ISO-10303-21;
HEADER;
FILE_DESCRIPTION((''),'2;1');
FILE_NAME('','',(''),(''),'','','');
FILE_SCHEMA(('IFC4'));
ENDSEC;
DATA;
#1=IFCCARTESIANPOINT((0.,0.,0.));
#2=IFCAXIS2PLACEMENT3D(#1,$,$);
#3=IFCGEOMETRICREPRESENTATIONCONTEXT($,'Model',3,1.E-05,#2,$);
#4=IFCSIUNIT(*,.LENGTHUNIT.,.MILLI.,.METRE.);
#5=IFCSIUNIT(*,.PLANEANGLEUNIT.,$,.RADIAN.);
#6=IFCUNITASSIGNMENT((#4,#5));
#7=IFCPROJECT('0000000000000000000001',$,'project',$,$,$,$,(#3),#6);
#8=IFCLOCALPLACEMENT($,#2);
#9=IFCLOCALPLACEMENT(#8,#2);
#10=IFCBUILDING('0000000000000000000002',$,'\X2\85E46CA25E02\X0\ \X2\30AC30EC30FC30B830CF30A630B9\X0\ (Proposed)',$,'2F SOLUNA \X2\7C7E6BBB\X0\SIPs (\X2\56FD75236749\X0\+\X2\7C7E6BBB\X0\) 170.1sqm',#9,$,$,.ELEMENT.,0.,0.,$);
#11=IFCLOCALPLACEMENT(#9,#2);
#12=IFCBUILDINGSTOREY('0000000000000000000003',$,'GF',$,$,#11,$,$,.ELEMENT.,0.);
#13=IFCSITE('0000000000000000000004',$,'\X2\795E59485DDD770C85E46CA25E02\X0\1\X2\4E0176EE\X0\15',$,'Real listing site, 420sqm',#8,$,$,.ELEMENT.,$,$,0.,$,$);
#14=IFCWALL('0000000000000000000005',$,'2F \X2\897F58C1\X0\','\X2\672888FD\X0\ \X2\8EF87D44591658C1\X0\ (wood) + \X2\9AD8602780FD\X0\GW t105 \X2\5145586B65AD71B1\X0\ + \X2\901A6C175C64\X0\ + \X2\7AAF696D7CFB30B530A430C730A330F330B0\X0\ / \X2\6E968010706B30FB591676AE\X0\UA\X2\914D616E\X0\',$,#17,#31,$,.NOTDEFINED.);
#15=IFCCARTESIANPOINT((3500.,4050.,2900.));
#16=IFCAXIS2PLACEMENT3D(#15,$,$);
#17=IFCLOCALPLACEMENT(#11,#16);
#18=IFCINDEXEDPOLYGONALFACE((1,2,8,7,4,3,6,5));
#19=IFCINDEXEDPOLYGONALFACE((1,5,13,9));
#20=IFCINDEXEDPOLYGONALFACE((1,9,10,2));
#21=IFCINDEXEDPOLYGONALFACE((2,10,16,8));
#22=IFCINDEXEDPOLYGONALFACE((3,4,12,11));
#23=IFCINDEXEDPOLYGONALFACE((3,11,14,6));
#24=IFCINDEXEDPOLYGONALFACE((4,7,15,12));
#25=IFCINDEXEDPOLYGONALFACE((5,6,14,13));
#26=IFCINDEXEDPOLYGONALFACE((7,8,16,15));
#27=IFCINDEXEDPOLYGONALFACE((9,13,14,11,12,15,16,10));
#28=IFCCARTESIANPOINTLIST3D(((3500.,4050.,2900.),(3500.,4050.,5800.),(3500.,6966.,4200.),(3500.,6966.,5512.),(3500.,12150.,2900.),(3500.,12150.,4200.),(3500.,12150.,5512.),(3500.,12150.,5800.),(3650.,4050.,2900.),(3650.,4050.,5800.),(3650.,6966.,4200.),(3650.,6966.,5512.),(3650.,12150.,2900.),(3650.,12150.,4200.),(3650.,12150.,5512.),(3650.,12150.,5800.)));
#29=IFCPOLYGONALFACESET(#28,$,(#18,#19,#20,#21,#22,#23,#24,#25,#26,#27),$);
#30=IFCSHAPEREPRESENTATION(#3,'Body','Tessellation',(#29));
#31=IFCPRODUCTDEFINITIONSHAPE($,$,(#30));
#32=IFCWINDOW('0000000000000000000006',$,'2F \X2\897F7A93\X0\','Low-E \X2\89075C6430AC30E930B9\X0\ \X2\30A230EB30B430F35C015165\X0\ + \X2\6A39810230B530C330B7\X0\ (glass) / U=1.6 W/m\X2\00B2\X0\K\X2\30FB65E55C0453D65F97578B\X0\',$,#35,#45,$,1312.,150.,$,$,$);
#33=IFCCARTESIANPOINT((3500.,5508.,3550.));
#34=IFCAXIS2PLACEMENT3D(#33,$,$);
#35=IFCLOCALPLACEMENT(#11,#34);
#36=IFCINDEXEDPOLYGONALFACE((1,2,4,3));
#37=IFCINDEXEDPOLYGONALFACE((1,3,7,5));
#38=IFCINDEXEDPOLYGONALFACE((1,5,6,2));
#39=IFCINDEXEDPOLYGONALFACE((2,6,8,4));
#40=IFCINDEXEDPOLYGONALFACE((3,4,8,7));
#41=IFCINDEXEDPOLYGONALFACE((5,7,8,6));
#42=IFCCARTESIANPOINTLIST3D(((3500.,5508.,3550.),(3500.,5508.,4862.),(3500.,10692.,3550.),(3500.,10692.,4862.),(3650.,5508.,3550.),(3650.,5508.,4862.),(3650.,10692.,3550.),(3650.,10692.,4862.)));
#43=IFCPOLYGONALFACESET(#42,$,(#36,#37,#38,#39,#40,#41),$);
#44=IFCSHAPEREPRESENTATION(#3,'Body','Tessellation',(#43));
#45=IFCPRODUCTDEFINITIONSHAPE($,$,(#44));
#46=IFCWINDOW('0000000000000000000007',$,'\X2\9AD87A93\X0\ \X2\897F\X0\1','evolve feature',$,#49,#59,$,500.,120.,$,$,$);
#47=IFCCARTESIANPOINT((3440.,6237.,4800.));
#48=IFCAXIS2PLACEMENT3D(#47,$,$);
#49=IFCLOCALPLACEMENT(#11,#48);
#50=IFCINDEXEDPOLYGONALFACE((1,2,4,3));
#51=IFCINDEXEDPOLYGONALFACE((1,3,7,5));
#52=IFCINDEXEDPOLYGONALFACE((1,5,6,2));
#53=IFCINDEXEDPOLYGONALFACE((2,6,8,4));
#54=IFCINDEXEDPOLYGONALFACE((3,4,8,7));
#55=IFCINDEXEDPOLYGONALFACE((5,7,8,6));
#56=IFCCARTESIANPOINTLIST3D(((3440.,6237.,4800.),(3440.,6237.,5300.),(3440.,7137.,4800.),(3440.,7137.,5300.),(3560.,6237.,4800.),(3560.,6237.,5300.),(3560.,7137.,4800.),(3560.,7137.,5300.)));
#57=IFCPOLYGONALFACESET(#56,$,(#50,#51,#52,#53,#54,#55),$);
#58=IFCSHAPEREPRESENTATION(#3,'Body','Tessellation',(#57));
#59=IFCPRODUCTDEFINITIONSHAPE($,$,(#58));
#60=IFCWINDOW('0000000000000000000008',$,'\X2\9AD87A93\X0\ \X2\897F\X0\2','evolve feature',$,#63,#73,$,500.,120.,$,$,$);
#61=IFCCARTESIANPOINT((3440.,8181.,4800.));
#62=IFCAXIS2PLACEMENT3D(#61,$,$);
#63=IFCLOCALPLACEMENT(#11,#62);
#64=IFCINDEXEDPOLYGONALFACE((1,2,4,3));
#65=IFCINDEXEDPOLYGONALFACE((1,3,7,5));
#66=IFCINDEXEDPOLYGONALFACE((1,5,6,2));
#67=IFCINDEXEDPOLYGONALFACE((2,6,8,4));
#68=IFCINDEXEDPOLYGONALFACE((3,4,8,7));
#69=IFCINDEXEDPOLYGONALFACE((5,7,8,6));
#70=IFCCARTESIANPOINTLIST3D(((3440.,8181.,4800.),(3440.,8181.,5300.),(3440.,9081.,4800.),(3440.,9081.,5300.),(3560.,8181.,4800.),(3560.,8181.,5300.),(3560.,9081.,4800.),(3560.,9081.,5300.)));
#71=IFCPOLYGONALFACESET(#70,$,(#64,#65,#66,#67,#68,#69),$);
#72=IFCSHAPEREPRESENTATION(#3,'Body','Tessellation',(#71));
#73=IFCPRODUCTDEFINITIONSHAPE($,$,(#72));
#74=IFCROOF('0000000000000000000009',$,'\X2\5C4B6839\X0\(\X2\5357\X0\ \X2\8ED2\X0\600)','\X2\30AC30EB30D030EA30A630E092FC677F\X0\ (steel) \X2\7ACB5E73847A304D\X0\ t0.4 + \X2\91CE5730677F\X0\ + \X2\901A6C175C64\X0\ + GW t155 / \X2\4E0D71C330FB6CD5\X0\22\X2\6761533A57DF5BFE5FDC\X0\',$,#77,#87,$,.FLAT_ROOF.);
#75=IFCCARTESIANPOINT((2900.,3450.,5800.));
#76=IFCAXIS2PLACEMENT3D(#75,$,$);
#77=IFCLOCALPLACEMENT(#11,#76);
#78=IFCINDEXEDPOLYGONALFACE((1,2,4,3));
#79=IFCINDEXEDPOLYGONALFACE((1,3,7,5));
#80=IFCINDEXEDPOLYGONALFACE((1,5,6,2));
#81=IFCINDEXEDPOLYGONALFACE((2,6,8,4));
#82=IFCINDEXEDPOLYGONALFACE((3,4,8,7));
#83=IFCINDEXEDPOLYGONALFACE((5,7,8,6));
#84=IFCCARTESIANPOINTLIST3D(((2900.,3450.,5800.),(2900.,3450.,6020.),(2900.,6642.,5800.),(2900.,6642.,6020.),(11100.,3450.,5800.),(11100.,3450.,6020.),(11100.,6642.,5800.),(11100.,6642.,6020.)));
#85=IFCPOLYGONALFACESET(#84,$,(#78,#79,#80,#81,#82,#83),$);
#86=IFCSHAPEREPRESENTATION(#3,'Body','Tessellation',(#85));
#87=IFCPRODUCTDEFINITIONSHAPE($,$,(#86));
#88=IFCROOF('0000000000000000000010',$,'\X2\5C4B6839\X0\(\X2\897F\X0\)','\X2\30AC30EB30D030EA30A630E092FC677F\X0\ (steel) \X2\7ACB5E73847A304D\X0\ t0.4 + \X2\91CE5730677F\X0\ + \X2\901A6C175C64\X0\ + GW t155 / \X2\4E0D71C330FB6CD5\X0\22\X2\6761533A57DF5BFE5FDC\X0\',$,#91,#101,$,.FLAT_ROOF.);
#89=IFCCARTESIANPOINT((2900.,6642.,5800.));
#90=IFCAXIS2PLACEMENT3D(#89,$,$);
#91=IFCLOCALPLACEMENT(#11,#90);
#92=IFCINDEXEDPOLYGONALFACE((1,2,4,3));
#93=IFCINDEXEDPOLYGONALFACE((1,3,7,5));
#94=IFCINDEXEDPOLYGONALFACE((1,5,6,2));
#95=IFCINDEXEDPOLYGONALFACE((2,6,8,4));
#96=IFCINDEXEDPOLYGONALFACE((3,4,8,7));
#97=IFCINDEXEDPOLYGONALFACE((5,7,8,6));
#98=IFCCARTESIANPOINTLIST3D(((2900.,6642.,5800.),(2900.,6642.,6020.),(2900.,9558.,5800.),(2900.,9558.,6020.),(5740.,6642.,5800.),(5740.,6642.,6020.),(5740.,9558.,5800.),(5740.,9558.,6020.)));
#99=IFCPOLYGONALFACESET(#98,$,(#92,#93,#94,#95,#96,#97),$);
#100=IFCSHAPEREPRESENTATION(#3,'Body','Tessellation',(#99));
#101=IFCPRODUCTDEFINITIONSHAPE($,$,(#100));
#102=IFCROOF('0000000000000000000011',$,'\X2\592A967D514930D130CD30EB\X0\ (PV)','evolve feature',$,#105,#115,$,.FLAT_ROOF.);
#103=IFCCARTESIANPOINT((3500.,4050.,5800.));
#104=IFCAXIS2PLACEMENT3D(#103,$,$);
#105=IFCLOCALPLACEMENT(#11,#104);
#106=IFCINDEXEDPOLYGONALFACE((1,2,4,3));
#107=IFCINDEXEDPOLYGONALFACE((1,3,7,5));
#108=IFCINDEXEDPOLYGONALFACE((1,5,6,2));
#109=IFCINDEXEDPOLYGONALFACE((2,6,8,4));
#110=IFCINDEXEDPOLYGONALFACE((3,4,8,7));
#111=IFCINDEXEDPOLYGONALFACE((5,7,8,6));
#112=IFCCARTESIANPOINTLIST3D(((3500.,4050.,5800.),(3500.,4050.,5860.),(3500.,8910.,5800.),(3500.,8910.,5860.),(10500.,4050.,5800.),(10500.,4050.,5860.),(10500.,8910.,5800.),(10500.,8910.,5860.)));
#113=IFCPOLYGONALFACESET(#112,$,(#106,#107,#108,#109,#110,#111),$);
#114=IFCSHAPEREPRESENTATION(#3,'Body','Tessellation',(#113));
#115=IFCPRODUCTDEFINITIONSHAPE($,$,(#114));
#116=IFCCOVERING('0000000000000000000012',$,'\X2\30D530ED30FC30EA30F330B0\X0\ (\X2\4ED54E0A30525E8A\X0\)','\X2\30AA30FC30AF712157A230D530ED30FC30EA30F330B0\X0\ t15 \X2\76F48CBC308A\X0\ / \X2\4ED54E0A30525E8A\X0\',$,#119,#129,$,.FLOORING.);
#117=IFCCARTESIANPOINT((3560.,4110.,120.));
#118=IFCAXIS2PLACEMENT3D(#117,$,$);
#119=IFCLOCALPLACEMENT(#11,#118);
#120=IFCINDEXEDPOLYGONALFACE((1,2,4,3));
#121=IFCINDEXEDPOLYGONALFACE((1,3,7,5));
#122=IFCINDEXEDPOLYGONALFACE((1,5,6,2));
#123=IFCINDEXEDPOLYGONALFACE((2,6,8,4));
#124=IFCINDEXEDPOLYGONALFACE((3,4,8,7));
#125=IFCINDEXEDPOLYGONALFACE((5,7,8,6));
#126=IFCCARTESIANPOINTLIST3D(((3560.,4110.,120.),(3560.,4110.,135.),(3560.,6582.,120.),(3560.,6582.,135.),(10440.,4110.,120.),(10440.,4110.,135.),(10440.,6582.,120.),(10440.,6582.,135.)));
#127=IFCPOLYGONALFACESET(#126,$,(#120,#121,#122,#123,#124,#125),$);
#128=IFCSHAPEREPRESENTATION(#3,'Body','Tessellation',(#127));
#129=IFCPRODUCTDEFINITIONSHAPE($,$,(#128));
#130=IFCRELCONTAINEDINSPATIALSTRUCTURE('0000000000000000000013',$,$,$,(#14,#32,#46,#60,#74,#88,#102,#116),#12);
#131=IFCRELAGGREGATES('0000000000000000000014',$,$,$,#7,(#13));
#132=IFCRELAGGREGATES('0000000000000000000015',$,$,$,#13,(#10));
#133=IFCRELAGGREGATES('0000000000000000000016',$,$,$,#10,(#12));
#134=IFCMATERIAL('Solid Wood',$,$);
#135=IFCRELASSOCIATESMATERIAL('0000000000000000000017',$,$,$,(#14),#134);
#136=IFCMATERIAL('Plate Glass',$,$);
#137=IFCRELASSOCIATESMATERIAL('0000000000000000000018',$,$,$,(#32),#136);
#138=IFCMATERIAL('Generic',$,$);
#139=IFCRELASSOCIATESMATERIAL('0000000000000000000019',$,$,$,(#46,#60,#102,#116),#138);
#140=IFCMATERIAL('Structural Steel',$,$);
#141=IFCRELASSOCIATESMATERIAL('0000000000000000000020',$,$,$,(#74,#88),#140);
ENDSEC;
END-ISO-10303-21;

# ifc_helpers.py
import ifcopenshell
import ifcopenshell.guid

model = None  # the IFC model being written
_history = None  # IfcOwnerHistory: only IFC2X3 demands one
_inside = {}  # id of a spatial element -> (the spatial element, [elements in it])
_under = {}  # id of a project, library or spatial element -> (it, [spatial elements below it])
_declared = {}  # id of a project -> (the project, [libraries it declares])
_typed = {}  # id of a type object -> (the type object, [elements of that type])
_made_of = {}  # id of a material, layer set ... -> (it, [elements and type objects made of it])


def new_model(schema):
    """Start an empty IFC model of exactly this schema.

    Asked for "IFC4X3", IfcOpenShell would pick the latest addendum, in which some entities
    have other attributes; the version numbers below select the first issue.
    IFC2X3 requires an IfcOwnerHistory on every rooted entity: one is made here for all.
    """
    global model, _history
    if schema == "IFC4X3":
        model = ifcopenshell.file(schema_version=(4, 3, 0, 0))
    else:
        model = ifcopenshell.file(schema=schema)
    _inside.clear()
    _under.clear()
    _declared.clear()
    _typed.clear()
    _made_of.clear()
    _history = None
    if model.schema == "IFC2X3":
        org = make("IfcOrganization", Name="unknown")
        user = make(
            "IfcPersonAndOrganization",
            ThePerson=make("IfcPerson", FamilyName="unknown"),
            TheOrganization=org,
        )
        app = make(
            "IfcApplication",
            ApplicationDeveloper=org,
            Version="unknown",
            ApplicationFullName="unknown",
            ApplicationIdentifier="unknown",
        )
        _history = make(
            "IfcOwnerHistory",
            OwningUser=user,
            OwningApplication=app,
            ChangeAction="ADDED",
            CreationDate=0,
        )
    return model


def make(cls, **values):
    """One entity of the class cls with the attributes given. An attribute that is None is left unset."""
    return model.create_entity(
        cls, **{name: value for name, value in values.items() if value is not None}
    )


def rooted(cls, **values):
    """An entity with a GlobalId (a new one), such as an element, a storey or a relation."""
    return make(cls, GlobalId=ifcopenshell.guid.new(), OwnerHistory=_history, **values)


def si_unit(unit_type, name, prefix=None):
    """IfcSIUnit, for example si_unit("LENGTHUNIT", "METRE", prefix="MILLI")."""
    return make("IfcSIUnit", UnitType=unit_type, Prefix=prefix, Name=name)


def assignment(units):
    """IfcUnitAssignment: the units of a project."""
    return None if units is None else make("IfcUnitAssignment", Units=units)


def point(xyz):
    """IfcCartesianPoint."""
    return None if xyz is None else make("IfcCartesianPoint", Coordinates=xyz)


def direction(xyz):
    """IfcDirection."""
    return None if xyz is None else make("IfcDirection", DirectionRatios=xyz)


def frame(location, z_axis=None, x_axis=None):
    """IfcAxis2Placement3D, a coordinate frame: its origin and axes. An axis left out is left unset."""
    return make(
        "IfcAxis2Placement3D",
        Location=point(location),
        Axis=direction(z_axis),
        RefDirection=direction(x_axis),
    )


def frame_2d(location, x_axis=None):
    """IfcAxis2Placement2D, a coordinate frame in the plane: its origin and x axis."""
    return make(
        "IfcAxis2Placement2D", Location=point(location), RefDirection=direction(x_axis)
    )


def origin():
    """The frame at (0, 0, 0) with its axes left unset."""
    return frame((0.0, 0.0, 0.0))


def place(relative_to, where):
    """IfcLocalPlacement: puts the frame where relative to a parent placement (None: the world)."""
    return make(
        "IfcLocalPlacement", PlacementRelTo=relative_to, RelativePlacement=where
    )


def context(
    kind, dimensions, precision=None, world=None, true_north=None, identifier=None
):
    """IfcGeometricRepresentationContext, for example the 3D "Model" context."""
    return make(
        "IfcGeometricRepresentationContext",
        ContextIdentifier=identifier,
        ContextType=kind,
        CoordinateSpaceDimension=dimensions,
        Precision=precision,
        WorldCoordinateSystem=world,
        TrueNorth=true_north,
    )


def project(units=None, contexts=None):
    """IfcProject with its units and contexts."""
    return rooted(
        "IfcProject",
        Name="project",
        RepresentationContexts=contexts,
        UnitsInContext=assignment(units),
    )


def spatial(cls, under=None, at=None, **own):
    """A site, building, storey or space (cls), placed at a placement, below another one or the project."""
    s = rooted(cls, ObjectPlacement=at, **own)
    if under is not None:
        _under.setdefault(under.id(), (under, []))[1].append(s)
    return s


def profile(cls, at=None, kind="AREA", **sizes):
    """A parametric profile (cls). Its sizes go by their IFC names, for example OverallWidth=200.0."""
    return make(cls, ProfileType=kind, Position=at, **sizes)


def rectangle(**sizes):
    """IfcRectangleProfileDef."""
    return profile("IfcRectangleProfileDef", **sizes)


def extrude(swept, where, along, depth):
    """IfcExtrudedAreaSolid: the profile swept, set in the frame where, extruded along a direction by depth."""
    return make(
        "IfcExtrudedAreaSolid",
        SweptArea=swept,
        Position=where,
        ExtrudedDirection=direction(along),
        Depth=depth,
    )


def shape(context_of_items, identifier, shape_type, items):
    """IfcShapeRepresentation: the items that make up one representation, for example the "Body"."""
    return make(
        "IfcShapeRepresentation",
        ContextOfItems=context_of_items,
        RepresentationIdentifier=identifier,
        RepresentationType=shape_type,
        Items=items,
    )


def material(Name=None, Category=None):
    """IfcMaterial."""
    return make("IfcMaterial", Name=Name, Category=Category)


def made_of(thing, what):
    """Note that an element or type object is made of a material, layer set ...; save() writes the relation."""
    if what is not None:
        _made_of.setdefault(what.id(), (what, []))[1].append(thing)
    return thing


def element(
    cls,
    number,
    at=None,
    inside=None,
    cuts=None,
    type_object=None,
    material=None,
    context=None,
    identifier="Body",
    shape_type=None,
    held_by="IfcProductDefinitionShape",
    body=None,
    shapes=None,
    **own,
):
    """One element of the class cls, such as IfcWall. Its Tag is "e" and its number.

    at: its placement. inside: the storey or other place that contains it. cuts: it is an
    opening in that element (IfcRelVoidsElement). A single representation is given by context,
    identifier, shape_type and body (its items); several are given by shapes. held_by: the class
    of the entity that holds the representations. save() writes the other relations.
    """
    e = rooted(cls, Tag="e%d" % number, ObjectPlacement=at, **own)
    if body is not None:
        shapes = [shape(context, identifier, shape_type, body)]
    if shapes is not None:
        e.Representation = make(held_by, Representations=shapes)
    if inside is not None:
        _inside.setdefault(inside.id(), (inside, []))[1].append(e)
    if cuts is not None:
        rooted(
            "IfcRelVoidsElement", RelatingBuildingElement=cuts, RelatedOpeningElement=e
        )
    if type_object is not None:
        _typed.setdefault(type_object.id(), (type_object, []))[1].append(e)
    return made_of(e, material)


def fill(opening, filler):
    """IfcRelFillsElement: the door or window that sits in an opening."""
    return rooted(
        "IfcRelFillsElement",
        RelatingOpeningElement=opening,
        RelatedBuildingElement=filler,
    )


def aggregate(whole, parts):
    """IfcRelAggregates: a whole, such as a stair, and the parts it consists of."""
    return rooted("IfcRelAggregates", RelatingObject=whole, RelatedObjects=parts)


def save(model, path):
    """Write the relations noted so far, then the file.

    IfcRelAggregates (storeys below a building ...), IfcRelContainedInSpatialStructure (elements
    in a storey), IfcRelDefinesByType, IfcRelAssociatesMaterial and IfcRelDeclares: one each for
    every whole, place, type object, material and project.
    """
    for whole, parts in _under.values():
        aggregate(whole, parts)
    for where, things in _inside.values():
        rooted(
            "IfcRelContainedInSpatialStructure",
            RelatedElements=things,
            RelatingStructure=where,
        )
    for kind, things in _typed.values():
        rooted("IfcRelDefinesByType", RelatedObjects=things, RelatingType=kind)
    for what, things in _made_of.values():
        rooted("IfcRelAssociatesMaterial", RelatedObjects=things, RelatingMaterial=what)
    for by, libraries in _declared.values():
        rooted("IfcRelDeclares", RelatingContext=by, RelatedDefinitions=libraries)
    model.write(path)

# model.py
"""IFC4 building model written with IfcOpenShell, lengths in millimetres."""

from ifc_helpers import new_model, si_unit, frame, frame_2d, origin, place, context, project, spatial, rectangle, extrude, material, element, fill, save


model = new_model("IFC4")

# Units and contexts
model_context = context("Model", 3, precision=1e-05, world=origin())
ifc_project = project(units=[si_unit("LENGTHUNIT", "METRE", prefix="MILLI"), si_unit("PLANEANGLEUNIT", "RADIAN")], contexts=[model_context])

# Site, building, storey
site_placement = place(None, origin())
site = spatial("IfcSite", under=ifc_project, at=site_placement, Name="神奈川県藤沢市1丁目15", ObjectType="Real listing site, 420sqm", CompositionType="ELEMENT", RefElevation=0.0)
building_placement = place(site_placement, origin())
building = spatial("IfcBuilding", under=site, at=building_placement, Name="藤沢市 ガレージハウス (Proposed)", ObjectType="2F SOLUNA 籾殻SIPs (国産杉+籾殻) 170.1sqm", CompositionType="ELEMENT", ElevationOfRefHeight=0.0, ElevationOfTerrain=0.0)
storey_placement = place(building_placement, origin())
storey = spatial("IfcBuildingStorey", under=building, at=storey_placement, Name="GF", CompositionType="ELEMENT", Elevation=0.0)

# Shared definitions
ifc_material_1 = material(Name="Solid Wood")
ifc_material_2 = material(Name="Generic")

# Shared definitions
ifc_material_3 = material(Name="Plate Glass")

# Wall, openings, windows
wall_1_placement = place(storey_placement, frame((3500.0, 4050.0, 2900.0)))
wall_1 = element("IfcWall", 1, at=wall_1_placement, inside=storey, material=ifc_material_1, Name="2F 西壁", Description="木製 軸組外壁 (wood) + 高性能GW t105 充填断熱 + 通気層 + 窯業系サイディング / 準耐火・外皮UA配慮", PredefinedType="NOTDEFINED", context=model_context, shape_type="SweptSolid", body=[
    extrude(rectangle(XDim=150.0, YDim=8100.0, at=frame_2d((75.0, 4050.0))), frame((3500.0, 4050.0, 2900.0)), (0.0, 0.0, 1.0), 2900.0),
])
opening_1_placement = place(storey_placement, frame((3500.0, 5508.0, 3550.0)))
opening_1 = element("IfcOpeningElement", 2, at=opening_1_placement, cuts=wall_1, PredefinedType="NOTDEFINED", context=model_context, shape_type="SweptSolid", body=[
    extrude(rectangle(XDim=150.0, YDim=5184.0, at=frame_2d((75.0, 2592.0))), frame((3500.0, 5508.0, 3550.0)), (0.0, 0.0, 1.0), 1312.0),
])
opening_2_placement = place(storey_placement, frame((3440.0, 6237.0, 4800.0)))
opening_2 = element("IfcOpeningElement", 3, at=opening_2_placement, cuts=wall_1, PredefinedType="NOTDEFINED", context=model_context, shape_type="SweptSolid", body=[
    extrude(rectangle(XDim=120.0, YDim=900.0, at=frame_2d((60.0, 450.0))), frame((3440.0, 6237.0, 4800.0)), (0.0, 0.0, 1.0), 500.0),
])
opening_3_placement = place(storey_placement, frame((3440.0, 8181.0, 4800.0)))
opening_3 = element("IfcOpeningElement", 4, at=opening_3_placement, cuts=wall_1, PredefinedType="NOTDEFINED", context=model_context, shape_type="SweptSolid", body=[
    extrude(rectangle(XDim=120.0, YDim=900.0, at=frame_2d((60.0, 450.0))), frame((3440.0, 8181.0, 4800.0)), (0.0, 0.0, 1.0), 500.0),
])
window_1_placement = place(storey_placement, frame((3500.0, 5508.0, 3550.0)))
window_1 = element("IfcWindow", 5, at=window_1_placement, inside=storey, material=ifc_material_3, Name="2F 西窓", Description="Low-E 複層ガラス アルゴン封入 + 樹脂サッシ (glass) / U=1.6 W/m²K・日射取得型", OverallHeight=1312.0, OverallWidth=150.0, context=model_context, shape_type="SweptSolid", body=[
    extrude(rectangle(XDim=150.0, YDim=5184.0, at=frame_2d((75.0, 2592.0))), frame((3500.0, 5508.0, 3550.0)), (0.0, 0.0, 1.0), 1312.0),
])
fill(opening_1, window_1)
window_2_placement = place(storey_placement, frame((3440.0, 6237.0, 4800.0)))
window_2 = element("IfcWindow", 6, at=window_2_placement, inside=storey, material=ifc_material_2, Name="高窓 西1", Description="evolve feature", OverallHeight=500.0, OverallWidth=120.0, context=model_context, shape_type="SweptSolid", body=[
    extrude(rectangle(XDim=120.0, YDim=900.0, at=frame_2d((60.0, 450.0))), frame((3440.0, 6237.0, 4800.0)), (0.0, 0.0, 1.0), 500.0),
])
fill(opening_2, window_2)
window_3_placement = place(storey_placement, frame((3440.0, 8181.0, 4800.0)))
window_3 = element("IfcWindow", 7, at=window_3_placement, inside=storey, material=ifc_material_2, Name="高窓 西2", Description="evolve feature", OverallHeight=500.0, OverallWidth=120.0, context=model_context, shape_type="SweptSolid", body=[
    extrude(rectangle(XDim=120.0, YDim=900.0, at=frame_2d((60.0, 450.0))), frame((3440.0, 8181.0, 4800.0)), (0.0, 0.0, 1.0), 500.0),
])
fill(opening_3, window_3)

# Roofs
ifc_material_4 = material(Name="Structural Steel")
roof_1_placement = place(storey_placement, frame((2900.0, 3450.0, 5800.0)))
element("IfcRoof", 8, at=roof_1_placement, inside=storey, material=ifc_material_4, Name="屋根(南 軒600)", Description="ガルバリウム鋼板 (steel) 立平葺き t0.4 + 野地板 + 通気層 + GW t155 / 不燃・法22条区域対応", PredefinedType="FLAT_ROOF", context=model_context, shape_type="SweptSolid", body=[
    extrude(rectangle(XDim=8200.0, YDim=3192.0, at=frame_2d((4100.0, 1596.0))), frame((2900.0, 3450.0, 5800.0)), (0.0, 0.0, 1.0), 220.0),
])
roof_2_placement = place(storey_placement, frame((2900.0, 6642.0, 5800.0)))
element("IfcRoof", 9, at=roof_2_placement, inside=storey, material=ifc_material_4, Name="屋根(西)", Description="ガルバリウム鋼板 (steel) 立平葺き t0.4 + 野地板 + 通気層 + GW t155 / 不燃・法22条区域対応", PredefinedType="FLAT_ROOF", context=model_context, shape_type="SweptSolid", body=[
    extrude(rectangle(XDim=2840.0, YDim=2916.0, at=frame_2d((1420.0, 1458.0))), frame((2900.0, 6642.0, 5800.0)), (0.0, 0.0, 1.0), 220.0),
])
roof_3_placement = place(storey_placement, frame((3500.0, 4050.0, 5800.0)))
element("IfcRoof", 10, at=roof_3_placement, inside=storey, material=ifc_material_2, Name="太陽光パネル (PV)", Description="evolve feature", PredefinedType="FLAT_ROOF", context=model_context, shape_type="SweptSolid", body=[
    extrude(rectangle(XDim=7000.0, YDim=4860.0, at=frame_2d((3500.0, 2430.0))), frame((3500.0, 4050.0, 5800.0)), (0.0, 0.0, 1.0), 60.0),
])

# Covering
covering_placement = place(storey_placement, frame((3560.0, 4110.0, 120.0)))
element("IfcCovering", 11, at=covering_placement, inside=storey, material=ifc_material_2, Name="フローリング (仕上げ床)", Description="オーク無垢フローリング t15 直貼り / 仕上げ床", PredefinedType="FLOORING", context=model_context, shape_type="SweptSolid", body=[
    extrude(rectangle(XDim=6880.0, YDim=2472.0, at=frame_2d((3440.0, 1236.0))), frame((3560.0, 4110.0, 120.0)), (0.0, 0.0, 1.0), 15.0),
])

save(model, "model.ifc")
